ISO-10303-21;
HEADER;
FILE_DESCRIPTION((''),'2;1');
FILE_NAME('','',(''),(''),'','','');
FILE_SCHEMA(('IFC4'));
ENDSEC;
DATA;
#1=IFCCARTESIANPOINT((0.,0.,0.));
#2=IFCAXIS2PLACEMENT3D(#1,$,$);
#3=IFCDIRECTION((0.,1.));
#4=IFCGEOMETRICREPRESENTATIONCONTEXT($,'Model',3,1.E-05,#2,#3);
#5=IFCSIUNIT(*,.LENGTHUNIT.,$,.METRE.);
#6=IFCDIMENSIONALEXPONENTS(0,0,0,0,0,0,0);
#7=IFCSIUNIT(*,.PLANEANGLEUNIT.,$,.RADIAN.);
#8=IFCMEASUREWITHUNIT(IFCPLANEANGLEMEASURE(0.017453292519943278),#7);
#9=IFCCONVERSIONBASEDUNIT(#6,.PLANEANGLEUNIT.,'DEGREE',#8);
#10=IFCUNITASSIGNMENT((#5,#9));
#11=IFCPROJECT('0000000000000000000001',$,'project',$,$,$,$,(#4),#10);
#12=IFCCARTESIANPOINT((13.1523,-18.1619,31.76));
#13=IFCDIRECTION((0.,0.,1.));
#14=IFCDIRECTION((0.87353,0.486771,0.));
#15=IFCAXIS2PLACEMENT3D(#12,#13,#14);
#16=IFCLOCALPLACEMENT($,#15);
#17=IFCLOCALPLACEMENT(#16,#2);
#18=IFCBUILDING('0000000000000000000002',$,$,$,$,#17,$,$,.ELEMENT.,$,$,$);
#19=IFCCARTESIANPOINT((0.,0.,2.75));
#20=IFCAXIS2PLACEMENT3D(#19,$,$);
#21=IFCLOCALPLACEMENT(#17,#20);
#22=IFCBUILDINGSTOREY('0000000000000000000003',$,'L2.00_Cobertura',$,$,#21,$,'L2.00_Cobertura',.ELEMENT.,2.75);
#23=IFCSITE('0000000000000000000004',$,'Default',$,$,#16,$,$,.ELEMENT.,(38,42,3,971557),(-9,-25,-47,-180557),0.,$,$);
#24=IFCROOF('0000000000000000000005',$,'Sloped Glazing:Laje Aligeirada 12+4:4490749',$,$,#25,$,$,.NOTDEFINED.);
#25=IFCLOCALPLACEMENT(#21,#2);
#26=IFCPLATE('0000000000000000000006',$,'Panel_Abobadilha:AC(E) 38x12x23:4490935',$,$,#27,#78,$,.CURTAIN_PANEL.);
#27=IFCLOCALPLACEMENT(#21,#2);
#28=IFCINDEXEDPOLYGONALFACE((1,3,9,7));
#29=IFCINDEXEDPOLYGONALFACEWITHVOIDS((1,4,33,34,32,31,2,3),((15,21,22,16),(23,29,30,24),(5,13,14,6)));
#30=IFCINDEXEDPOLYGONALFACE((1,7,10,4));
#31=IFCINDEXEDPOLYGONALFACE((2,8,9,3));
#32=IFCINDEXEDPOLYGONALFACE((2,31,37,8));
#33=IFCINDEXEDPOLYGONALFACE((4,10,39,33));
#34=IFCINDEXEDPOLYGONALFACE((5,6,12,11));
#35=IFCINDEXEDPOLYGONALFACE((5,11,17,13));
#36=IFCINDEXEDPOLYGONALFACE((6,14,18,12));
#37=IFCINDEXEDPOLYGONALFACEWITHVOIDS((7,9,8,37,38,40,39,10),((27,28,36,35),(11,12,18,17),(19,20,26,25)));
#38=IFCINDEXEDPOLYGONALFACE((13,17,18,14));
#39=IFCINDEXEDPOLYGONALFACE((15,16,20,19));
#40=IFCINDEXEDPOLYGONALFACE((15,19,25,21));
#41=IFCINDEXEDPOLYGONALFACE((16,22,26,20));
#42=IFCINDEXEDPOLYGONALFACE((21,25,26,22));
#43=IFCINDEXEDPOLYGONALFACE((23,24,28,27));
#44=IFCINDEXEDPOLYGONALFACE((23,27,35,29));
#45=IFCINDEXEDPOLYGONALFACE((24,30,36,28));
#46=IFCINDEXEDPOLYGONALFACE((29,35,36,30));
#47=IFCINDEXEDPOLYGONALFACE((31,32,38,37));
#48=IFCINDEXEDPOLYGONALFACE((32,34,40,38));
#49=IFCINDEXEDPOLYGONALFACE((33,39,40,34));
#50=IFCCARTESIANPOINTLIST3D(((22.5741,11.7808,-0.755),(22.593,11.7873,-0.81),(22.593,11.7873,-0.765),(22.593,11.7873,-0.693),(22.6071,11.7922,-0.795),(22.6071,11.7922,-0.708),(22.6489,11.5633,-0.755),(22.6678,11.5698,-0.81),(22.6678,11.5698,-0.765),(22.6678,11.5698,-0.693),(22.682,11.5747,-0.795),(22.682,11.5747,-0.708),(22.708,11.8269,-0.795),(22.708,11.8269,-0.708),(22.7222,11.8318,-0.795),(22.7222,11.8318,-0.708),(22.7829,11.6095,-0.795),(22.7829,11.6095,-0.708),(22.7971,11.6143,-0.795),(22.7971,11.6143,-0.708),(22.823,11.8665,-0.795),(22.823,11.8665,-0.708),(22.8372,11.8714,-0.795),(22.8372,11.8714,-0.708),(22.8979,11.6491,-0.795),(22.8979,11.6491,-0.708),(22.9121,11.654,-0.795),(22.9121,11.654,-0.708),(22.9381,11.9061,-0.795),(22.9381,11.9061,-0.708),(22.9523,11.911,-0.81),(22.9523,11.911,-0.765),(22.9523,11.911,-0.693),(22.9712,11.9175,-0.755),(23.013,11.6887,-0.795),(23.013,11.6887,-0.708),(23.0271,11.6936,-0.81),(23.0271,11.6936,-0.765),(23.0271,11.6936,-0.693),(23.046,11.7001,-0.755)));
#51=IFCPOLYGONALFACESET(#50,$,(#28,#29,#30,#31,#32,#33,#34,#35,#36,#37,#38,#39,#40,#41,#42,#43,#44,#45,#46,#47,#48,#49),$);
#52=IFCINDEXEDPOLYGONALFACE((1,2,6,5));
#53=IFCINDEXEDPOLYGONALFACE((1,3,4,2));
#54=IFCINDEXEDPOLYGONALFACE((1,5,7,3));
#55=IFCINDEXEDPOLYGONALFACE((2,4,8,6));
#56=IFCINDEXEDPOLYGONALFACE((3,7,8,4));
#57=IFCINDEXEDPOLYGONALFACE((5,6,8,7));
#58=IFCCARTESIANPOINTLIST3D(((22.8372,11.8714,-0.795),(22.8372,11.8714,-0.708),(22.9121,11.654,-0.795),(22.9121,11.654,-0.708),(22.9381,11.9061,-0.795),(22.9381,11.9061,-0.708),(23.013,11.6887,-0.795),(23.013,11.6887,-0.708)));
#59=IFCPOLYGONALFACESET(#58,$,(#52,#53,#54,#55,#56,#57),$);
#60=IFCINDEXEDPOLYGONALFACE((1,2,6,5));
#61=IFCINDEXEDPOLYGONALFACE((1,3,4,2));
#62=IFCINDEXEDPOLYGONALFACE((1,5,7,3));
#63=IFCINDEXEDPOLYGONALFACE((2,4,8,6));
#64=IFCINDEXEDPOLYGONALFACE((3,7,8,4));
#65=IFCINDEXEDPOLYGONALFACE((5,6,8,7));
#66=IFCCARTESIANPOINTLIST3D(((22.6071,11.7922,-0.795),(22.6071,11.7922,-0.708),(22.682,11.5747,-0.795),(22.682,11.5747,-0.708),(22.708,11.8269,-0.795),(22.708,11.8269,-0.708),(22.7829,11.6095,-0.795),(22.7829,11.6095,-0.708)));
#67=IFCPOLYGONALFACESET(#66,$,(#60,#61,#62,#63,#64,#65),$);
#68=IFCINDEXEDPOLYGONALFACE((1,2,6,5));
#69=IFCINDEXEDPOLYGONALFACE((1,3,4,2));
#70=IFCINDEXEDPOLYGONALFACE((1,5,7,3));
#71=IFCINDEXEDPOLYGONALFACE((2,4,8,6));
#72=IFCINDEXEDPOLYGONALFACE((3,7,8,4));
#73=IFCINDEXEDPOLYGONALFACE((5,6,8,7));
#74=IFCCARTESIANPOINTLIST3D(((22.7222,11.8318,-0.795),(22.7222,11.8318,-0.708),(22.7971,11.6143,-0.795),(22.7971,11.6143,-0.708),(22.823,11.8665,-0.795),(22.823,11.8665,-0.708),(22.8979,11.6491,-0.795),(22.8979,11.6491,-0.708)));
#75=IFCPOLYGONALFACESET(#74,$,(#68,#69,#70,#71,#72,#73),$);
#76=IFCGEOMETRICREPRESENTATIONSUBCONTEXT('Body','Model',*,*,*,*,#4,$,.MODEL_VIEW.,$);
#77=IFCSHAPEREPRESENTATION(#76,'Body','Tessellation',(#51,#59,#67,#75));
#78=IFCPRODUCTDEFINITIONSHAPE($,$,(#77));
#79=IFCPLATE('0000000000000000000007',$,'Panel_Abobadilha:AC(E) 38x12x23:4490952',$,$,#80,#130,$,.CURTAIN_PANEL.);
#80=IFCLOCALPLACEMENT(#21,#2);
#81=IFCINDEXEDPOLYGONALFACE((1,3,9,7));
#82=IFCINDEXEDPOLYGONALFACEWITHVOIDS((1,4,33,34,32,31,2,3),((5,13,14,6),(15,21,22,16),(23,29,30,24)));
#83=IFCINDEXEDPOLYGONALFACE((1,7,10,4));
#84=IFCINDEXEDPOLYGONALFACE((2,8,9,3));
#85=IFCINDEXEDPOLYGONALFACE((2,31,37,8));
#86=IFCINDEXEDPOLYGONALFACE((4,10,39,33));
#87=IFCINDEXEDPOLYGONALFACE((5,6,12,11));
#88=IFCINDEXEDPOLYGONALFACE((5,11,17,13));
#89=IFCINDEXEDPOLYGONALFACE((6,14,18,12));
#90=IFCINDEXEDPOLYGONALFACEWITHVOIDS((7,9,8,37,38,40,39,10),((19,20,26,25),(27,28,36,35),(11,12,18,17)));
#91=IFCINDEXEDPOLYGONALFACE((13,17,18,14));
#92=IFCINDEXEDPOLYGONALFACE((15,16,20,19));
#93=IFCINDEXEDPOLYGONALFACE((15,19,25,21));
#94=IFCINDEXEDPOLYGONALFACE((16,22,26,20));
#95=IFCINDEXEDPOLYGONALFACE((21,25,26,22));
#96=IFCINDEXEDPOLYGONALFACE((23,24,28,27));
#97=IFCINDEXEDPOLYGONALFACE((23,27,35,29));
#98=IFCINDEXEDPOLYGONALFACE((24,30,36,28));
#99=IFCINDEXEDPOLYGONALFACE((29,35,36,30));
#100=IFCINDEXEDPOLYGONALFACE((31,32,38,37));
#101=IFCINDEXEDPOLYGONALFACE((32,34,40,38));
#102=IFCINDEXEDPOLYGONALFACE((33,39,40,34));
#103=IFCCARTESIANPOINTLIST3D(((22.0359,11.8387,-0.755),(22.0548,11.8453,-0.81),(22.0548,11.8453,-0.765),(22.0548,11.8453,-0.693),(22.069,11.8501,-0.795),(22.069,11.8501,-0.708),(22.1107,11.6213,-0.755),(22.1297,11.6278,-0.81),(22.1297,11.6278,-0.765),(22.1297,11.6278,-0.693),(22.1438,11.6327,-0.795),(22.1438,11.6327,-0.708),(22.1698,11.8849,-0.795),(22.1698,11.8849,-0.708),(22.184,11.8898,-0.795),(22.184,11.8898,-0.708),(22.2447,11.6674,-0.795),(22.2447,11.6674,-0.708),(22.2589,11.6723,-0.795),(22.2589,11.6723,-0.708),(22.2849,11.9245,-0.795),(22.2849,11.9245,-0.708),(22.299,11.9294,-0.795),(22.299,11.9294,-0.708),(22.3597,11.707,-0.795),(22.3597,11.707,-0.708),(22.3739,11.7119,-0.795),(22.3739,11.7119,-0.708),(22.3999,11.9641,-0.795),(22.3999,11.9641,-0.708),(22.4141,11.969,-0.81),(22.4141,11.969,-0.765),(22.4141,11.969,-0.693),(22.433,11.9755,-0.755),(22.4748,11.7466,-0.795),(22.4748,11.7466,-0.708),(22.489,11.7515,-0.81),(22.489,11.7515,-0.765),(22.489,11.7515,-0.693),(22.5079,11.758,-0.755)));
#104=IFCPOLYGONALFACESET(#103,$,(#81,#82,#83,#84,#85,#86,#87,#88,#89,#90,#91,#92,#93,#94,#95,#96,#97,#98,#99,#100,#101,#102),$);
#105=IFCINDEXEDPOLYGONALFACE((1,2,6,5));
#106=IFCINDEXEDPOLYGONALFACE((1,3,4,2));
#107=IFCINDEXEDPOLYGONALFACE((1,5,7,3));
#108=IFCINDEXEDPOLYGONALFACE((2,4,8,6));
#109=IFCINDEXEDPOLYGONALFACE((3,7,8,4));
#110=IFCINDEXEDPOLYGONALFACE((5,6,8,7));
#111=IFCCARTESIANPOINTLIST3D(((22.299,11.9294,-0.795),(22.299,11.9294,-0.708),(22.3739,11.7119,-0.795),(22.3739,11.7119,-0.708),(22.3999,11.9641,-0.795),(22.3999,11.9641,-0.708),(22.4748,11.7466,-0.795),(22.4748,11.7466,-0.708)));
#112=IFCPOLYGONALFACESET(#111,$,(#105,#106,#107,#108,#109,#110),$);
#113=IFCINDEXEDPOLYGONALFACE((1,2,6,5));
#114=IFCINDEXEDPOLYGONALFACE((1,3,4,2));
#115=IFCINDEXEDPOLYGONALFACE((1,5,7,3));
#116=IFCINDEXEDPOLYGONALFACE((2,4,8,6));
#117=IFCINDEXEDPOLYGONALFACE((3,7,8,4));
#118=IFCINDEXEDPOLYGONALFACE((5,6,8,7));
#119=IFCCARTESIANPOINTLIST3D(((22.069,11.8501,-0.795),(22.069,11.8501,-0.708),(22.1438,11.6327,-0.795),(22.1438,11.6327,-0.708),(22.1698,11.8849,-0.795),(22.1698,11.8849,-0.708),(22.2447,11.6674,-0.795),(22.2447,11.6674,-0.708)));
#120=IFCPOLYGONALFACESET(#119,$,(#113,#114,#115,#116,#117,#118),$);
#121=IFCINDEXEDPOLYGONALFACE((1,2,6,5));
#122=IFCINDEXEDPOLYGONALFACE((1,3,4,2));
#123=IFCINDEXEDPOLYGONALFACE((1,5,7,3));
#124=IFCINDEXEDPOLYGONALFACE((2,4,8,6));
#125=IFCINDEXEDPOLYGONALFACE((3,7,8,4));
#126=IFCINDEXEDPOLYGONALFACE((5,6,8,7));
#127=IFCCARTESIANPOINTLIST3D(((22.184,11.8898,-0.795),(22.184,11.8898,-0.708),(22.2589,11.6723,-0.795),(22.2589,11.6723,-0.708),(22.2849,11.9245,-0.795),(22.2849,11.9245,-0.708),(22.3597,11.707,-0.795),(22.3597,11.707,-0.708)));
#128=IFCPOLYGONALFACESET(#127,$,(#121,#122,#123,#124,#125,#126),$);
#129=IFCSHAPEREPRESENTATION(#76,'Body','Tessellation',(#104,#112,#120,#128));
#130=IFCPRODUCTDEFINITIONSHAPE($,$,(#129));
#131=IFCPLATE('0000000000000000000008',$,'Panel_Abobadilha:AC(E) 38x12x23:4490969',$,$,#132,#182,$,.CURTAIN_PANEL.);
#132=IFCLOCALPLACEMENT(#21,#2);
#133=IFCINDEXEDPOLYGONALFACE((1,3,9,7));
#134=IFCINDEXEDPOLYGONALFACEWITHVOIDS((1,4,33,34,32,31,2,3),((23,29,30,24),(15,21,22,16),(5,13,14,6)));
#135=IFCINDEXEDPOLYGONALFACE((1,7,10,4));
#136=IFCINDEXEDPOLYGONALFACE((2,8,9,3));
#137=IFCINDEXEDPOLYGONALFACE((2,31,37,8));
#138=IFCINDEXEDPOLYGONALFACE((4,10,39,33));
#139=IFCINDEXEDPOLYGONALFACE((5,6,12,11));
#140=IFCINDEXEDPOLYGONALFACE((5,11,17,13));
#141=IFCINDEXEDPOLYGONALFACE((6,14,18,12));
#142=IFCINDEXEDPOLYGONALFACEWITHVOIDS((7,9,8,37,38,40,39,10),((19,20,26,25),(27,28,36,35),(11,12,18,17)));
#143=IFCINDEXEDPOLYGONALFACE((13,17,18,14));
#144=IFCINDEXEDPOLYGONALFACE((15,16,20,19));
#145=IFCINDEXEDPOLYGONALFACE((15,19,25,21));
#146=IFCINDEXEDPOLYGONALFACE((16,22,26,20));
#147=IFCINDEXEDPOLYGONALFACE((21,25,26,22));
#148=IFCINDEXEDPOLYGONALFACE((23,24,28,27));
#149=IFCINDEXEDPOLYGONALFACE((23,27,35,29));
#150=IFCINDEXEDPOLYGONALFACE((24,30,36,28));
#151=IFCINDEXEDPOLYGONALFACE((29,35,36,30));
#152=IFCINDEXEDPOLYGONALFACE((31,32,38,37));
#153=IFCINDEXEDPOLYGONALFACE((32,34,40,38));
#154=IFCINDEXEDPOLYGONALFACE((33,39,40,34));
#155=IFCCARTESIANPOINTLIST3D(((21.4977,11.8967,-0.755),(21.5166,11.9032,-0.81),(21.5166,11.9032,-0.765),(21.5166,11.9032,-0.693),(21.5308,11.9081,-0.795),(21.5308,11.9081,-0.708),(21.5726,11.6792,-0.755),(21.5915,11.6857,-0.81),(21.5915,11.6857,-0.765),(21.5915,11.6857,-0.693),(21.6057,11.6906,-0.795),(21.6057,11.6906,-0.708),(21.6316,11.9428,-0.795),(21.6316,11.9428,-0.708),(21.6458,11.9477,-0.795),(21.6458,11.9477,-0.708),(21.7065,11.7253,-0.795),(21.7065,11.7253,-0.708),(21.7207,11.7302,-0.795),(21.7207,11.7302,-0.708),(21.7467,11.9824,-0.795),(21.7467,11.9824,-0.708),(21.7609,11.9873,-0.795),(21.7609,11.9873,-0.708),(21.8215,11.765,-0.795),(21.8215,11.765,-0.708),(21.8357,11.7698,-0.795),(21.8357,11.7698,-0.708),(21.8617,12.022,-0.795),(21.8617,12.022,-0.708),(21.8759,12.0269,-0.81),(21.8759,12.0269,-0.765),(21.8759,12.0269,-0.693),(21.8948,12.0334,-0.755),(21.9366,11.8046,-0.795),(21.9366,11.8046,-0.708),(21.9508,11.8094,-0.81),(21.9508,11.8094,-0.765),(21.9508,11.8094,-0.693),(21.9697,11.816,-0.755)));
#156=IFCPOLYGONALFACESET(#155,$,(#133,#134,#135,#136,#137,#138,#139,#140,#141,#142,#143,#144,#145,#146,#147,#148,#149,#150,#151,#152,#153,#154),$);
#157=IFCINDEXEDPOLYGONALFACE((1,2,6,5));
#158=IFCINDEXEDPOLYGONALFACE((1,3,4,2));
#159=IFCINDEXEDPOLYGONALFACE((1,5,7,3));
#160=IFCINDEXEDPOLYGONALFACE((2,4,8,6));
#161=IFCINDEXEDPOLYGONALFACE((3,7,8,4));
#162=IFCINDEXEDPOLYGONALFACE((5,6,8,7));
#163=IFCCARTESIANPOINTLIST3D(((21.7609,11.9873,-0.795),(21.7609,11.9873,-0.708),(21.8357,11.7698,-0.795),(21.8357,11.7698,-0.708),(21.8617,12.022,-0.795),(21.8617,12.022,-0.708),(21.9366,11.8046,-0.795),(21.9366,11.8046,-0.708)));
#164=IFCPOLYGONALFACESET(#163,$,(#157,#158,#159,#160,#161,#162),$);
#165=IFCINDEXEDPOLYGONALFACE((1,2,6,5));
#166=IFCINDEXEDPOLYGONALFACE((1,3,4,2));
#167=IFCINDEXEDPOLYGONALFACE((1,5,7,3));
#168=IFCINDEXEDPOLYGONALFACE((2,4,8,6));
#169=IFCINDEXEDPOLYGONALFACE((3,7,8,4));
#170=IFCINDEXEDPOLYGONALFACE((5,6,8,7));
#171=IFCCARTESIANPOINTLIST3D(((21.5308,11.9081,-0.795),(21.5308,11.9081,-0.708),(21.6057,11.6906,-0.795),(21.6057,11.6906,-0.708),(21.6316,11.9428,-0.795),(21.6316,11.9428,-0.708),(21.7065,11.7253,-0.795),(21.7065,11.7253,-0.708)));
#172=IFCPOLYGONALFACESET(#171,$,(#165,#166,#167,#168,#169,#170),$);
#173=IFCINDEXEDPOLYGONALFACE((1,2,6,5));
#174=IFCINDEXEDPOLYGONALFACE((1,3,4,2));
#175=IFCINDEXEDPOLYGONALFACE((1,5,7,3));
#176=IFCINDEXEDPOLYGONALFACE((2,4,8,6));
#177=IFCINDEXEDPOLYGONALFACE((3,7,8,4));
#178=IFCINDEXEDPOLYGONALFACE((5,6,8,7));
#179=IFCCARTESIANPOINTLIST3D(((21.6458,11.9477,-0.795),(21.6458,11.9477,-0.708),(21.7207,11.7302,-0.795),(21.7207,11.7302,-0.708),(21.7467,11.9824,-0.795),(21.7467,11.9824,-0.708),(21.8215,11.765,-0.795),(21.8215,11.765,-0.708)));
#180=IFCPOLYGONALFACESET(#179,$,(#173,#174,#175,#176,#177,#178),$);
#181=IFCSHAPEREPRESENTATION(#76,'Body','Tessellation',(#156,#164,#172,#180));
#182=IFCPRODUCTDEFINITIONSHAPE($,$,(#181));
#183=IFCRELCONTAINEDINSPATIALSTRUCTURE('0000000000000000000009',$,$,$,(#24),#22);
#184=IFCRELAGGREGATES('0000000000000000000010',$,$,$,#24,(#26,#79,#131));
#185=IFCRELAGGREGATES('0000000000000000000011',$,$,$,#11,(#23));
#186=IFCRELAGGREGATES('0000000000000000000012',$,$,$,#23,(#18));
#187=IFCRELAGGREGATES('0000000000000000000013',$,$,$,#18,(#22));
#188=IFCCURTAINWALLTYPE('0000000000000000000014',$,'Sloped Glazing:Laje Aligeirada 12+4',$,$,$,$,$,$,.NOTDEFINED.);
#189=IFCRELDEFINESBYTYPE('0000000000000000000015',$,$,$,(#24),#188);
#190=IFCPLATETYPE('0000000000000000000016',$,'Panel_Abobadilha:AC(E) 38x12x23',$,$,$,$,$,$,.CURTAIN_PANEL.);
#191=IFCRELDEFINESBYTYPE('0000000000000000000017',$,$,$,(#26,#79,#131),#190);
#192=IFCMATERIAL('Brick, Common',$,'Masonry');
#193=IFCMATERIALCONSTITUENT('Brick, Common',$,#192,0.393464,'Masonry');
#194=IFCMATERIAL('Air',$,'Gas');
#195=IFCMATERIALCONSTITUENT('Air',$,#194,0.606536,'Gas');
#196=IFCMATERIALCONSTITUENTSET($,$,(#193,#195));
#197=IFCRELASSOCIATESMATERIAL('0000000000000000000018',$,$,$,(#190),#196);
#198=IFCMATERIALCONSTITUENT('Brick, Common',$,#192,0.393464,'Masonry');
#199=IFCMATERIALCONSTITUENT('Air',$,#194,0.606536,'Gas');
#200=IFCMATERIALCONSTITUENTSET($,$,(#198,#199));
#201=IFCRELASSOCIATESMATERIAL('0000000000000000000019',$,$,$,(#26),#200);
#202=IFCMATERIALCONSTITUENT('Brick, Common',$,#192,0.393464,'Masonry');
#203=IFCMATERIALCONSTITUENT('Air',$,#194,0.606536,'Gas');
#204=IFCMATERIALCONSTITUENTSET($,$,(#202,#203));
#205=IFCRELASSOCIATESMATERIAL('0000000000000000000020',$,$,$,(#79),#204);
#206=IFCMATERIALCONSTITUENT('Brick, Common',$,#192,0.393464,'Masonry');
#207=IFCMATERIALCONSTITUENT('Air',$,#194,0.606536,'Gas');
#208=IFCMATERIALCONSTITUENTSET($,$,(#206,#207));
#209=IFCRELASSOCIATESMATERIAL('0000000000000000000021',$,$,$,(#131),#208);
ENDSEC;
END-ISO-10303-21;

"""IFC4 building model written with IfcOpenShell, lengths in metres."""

from ifc_helpers import new_model, entity, si_unit, converted_unit, direction, frame, origin, place, context, subcontext, project, spatial, indexed_curve, outline, extrude, source, transform, mapped, material, constituent, constituent_set, type_object, type_shapes, element, aggregate, save


model = new_model("IFC4")

# Units and contexts
model_context = context("Model", 3, precision=1e-05, world=origin(), true_north=direction((0.0, 1.0)))
body_context = subcontext(model_context, "Body", "Model", "MODEL_VIEW")
ifc_project = project(units=[si_unit("LENGTHUNIT", "METRE"), converted_unit("PLANEANGLEUNIT", "DEGREE", entity("IfcPlaneAngleMeasure", 0.017453292519943278), si_unit("PLANEANGLEUNIT", "RADIAN"), dimensions=[0, 0, 0, 0, 0, 0, 0])], contexts=[model_context])

# Site, building, storey
site_placement = place(None, frame((13.1523, -18.1619, 31.76), z_axis=(0.0, 0.0, 1.0), x_axis=(0.87353, 0.486771, 0.0)))
site = spatial("IfcSite", under=ifc_project, at=site_placement, Name="Default", CompositionType="ELEMENT", RefLatitude=(38, 42, 3, 971557), RefLongitude=(-9, -25, -47, -180557), RefElevation=0.0)
building_placement = place(site_placement, origin())
building = spatial("IfcBuilding", under=site, at=building_placement, CompositionType="ELEMENT")
storey_placement = place(building_placement, frame((0.0, 0.0, 2.75)))
storey = spatial("IfcBuildingStorey", under=building, at=storey_placement, Name="L2.00_Cobertura", LongName="L2.00_Cobertura", CompositionType="ELEMENT", Elevation=2.75)

# Roof, plates
curtain_wall_type = type_object("IfcCurtainWallType", Name="Sloped Glazing:Laje Aligeirada 12+4", PredefinedType="NOTDEFINED")
roof_placement = place(storey_placement, frame((0.0, 0.0, -2.75)))
roof = element("IfcRoof", 1, at=roof_placement, inside=storey, type_object=curtain_wall_type, Name="Sloped Glazing:Laje Aligeirada 12+4:4490749", PredefinedType="NOTDEFINED")
ifc_material_1 = material(Name="Brick, Common", Category="Masonry")
ifc_material_2 = material(Name="Air", Category="Gas")
ifc_constituent_1 = constituent(ifc_material_1, Name="Brick, Common", Category="Masonry", fraction=0.393464)
ifc_constituent_2 = constituent(ifc_material_2, Name="Air", Category="Gas", fraction=0.606536)
ifc_constituent_set_1 = constituent_set(constituents=[ifc_constituent_1, ifc_constituent_2])
plate_type_1 = type_object("IfcPlateType", Name="Panel_Abobadilha:AC(E) 38x12x23", PredefinedType="CURTAIN_PANEL", material=ifc_constituent_set_1)
shared_shape_1 = source(origin(), body_context, "Body", "SweptSolid", [
    extrude(outline(indexed_curve([(-0.19, -0.0543), (0.19, -0.0543), (0.19, -0.0093), (0.21, 0.0007), (0.19, 0.0628), (-0.19, 0.0628), (-0.21, 0.0007), (-0.19, -0.0093), (-0.19, -0.0543)], self_intersect=False), holes=[indexed_curve([(-0.0683, 0.0477), (-0.0683, -0.0393), (-0.175, -0.0393), (-0.175, 0.0477), (-0.0683, 0.0477)], self_intersect=False), indexed_curve([(0.0533, 0.0477), (0.0533, -0.0393), (-0.0533, -0.0393), (-0.0533, 0.0477), (0.0533, 0.0477)], self_intersect=False), indexed_curve([(0.175, 0.0477), (0.175, -0.0393), (0.0683, -0.0393), (0.0683, 0.0477), (0.175, 0.0477)], self_intersect=False)]), frame((0.0, 0.0543, 0.0)), (0.0, 0.0, 1.0), 0.23),
    extrude(outline(indexed_curve([(-0.0533, -0.0435), (0.0533, -0.0435), (0.0533, 0.0435), (-0.0533, 0.0435), (-0.0533, -0.0435)], self_intersect=False)), frame((0.1217, 0.0585, 0.0), z_axis=(0.0, 0.0, 1.0), x_axis=(-1.0, 0.0, 0.0)), (0.0, 0.0, 1.0), 0.23),
    extrude(outline(indexed_curve([(-0.0533, -0.0435), (0.0533, -0.0435), (0.0533, 0.0435), (-0.0533, 0.0435), (-0.0533, -0.0435)], self_intersect=False)), frame((-0.1217, 0.0585, 0.0), z_axis=(0.0, 0.0, 1.0), x_axis=(-1.0, 0.0, 0.0)), (0.0, 0.0, 1.0), 0.23),
    extrude(outline(indexed_curve([(-0.0533, -0.0435), (0.0533, -0.0435), (0.0533, 0.0435), (-0.0533, 0.0435), (-0.0533, -0.0435)], self_intersect=False)), frame((0.0, 0.0585, 0.0), z_axis=(0.0, 0.0, 1.0), x_axis=(-1.0, 0.0, 0.0)), (0.0, 0.0, 1.0), 0.23),
])
type_shapes(plate_type_1, [shared_shape_1])
ifc_constituent_3 = constituent(ifc_material_1, Name="Brick, Common", Category="Masonry", fraction=0.393464)
ifc_constituent_4 = constituent(ifc_material_2, Name="Air", Category="Gas", fraction=0.606536)
ifc_constituent_set_2 = constituent_set(constituents=[ifc_constituent_3, ifc_constituent_4])
plate_1_placement = place(roof_placement, frame((22.7726, 11.8492, 1.94), z_axis=(0.325568, -0.945519, 0.0), x_axis=(0.945519, 0.325568, 0.0)))
plate_1 = element("IfcPlate", 2, at=plate_1_placement, type_object=plate_type_1, material=ifc_constituent_set_2, Name="Panel_Abobadilha:AC(E) 38x12x23:4490935", PredefinedType="CURTAIN_PANEL", context=body_context, shape_type="MappedRepresentation", body=[
    mapped(shared_shape_1, transform((0.0, 0.0, 0.0), scale=1.0)),
])
ifc_constituent_5 = constituent(ifc_material_1, Name="Brick, Common", Category="Masonry", fraction=0.393464)
ifc_constituent_6 = constituent(ifc_material_2, Name="Air", Category="Gas", fraction=0.606536)
ifc_constituent_set_3 = constituent_set(constituents=[ifc_constituent_5, ifc_constituent_6])
plate_2_placement = place(roof_placement, frame((22.2344, 11.9071, 1.94), z_axis=(0.325568, -0.945519, 0.0), x_axis=(0.945519, 0.325568, 0.0)))
plate_2 = element("IfcPlate", 3, at=plate_2_placement, type_object=plate_type_1, material=ifc_constituent_set_3, Name="Panel_Abobadilha:AC(E) 38x12x23:4490952", PredefinedType="CURTAIN_PANEL", context=body_context, shape_type="MappedRepresentation", body=[
    mapped(shared_shape_1, transform((0.0, 0.0, 0.0), scale=1.0)),
])
ifc_constituent_7 = constituent(ifc_material_1, Name="Brick, Common", Category="Masonry", fraction=0.393464)
ifc_constituent_8 = constituent(ifc_material_2, Name="Air", Category="Gas", fraction=0.606536)
ifc_constituent_set_4 = constituent_set(constituents=[ifc_constituent_7, ifc_constituent_8])
plate_3_placement = place(roof_placement, frame((21.6962, 11.9651, 1.94), z_axis=(0.325568, -0.945519, 0.0), x_axis=(0.945519, 0.325568, 0.0)))
plate_3 = element("IfcPlate", 4, at=plate_3_placement, type_object=plate_type_1, material=ifc_constituent_set_4, Name="Panel_Abobadilha:AC(E) 38x12x23:4490969", PredefinedType="CURTAIN_PANEL", context=body_context, shape_type="MappedRepresentation", body=[
    mapped(shared_shape_1, transform((0.0, 0.0, 0.0), scale=1.0)),
])
aggregate(roof, [plate_1, plate_2, plate_3])

save(model, "model.ifc")
